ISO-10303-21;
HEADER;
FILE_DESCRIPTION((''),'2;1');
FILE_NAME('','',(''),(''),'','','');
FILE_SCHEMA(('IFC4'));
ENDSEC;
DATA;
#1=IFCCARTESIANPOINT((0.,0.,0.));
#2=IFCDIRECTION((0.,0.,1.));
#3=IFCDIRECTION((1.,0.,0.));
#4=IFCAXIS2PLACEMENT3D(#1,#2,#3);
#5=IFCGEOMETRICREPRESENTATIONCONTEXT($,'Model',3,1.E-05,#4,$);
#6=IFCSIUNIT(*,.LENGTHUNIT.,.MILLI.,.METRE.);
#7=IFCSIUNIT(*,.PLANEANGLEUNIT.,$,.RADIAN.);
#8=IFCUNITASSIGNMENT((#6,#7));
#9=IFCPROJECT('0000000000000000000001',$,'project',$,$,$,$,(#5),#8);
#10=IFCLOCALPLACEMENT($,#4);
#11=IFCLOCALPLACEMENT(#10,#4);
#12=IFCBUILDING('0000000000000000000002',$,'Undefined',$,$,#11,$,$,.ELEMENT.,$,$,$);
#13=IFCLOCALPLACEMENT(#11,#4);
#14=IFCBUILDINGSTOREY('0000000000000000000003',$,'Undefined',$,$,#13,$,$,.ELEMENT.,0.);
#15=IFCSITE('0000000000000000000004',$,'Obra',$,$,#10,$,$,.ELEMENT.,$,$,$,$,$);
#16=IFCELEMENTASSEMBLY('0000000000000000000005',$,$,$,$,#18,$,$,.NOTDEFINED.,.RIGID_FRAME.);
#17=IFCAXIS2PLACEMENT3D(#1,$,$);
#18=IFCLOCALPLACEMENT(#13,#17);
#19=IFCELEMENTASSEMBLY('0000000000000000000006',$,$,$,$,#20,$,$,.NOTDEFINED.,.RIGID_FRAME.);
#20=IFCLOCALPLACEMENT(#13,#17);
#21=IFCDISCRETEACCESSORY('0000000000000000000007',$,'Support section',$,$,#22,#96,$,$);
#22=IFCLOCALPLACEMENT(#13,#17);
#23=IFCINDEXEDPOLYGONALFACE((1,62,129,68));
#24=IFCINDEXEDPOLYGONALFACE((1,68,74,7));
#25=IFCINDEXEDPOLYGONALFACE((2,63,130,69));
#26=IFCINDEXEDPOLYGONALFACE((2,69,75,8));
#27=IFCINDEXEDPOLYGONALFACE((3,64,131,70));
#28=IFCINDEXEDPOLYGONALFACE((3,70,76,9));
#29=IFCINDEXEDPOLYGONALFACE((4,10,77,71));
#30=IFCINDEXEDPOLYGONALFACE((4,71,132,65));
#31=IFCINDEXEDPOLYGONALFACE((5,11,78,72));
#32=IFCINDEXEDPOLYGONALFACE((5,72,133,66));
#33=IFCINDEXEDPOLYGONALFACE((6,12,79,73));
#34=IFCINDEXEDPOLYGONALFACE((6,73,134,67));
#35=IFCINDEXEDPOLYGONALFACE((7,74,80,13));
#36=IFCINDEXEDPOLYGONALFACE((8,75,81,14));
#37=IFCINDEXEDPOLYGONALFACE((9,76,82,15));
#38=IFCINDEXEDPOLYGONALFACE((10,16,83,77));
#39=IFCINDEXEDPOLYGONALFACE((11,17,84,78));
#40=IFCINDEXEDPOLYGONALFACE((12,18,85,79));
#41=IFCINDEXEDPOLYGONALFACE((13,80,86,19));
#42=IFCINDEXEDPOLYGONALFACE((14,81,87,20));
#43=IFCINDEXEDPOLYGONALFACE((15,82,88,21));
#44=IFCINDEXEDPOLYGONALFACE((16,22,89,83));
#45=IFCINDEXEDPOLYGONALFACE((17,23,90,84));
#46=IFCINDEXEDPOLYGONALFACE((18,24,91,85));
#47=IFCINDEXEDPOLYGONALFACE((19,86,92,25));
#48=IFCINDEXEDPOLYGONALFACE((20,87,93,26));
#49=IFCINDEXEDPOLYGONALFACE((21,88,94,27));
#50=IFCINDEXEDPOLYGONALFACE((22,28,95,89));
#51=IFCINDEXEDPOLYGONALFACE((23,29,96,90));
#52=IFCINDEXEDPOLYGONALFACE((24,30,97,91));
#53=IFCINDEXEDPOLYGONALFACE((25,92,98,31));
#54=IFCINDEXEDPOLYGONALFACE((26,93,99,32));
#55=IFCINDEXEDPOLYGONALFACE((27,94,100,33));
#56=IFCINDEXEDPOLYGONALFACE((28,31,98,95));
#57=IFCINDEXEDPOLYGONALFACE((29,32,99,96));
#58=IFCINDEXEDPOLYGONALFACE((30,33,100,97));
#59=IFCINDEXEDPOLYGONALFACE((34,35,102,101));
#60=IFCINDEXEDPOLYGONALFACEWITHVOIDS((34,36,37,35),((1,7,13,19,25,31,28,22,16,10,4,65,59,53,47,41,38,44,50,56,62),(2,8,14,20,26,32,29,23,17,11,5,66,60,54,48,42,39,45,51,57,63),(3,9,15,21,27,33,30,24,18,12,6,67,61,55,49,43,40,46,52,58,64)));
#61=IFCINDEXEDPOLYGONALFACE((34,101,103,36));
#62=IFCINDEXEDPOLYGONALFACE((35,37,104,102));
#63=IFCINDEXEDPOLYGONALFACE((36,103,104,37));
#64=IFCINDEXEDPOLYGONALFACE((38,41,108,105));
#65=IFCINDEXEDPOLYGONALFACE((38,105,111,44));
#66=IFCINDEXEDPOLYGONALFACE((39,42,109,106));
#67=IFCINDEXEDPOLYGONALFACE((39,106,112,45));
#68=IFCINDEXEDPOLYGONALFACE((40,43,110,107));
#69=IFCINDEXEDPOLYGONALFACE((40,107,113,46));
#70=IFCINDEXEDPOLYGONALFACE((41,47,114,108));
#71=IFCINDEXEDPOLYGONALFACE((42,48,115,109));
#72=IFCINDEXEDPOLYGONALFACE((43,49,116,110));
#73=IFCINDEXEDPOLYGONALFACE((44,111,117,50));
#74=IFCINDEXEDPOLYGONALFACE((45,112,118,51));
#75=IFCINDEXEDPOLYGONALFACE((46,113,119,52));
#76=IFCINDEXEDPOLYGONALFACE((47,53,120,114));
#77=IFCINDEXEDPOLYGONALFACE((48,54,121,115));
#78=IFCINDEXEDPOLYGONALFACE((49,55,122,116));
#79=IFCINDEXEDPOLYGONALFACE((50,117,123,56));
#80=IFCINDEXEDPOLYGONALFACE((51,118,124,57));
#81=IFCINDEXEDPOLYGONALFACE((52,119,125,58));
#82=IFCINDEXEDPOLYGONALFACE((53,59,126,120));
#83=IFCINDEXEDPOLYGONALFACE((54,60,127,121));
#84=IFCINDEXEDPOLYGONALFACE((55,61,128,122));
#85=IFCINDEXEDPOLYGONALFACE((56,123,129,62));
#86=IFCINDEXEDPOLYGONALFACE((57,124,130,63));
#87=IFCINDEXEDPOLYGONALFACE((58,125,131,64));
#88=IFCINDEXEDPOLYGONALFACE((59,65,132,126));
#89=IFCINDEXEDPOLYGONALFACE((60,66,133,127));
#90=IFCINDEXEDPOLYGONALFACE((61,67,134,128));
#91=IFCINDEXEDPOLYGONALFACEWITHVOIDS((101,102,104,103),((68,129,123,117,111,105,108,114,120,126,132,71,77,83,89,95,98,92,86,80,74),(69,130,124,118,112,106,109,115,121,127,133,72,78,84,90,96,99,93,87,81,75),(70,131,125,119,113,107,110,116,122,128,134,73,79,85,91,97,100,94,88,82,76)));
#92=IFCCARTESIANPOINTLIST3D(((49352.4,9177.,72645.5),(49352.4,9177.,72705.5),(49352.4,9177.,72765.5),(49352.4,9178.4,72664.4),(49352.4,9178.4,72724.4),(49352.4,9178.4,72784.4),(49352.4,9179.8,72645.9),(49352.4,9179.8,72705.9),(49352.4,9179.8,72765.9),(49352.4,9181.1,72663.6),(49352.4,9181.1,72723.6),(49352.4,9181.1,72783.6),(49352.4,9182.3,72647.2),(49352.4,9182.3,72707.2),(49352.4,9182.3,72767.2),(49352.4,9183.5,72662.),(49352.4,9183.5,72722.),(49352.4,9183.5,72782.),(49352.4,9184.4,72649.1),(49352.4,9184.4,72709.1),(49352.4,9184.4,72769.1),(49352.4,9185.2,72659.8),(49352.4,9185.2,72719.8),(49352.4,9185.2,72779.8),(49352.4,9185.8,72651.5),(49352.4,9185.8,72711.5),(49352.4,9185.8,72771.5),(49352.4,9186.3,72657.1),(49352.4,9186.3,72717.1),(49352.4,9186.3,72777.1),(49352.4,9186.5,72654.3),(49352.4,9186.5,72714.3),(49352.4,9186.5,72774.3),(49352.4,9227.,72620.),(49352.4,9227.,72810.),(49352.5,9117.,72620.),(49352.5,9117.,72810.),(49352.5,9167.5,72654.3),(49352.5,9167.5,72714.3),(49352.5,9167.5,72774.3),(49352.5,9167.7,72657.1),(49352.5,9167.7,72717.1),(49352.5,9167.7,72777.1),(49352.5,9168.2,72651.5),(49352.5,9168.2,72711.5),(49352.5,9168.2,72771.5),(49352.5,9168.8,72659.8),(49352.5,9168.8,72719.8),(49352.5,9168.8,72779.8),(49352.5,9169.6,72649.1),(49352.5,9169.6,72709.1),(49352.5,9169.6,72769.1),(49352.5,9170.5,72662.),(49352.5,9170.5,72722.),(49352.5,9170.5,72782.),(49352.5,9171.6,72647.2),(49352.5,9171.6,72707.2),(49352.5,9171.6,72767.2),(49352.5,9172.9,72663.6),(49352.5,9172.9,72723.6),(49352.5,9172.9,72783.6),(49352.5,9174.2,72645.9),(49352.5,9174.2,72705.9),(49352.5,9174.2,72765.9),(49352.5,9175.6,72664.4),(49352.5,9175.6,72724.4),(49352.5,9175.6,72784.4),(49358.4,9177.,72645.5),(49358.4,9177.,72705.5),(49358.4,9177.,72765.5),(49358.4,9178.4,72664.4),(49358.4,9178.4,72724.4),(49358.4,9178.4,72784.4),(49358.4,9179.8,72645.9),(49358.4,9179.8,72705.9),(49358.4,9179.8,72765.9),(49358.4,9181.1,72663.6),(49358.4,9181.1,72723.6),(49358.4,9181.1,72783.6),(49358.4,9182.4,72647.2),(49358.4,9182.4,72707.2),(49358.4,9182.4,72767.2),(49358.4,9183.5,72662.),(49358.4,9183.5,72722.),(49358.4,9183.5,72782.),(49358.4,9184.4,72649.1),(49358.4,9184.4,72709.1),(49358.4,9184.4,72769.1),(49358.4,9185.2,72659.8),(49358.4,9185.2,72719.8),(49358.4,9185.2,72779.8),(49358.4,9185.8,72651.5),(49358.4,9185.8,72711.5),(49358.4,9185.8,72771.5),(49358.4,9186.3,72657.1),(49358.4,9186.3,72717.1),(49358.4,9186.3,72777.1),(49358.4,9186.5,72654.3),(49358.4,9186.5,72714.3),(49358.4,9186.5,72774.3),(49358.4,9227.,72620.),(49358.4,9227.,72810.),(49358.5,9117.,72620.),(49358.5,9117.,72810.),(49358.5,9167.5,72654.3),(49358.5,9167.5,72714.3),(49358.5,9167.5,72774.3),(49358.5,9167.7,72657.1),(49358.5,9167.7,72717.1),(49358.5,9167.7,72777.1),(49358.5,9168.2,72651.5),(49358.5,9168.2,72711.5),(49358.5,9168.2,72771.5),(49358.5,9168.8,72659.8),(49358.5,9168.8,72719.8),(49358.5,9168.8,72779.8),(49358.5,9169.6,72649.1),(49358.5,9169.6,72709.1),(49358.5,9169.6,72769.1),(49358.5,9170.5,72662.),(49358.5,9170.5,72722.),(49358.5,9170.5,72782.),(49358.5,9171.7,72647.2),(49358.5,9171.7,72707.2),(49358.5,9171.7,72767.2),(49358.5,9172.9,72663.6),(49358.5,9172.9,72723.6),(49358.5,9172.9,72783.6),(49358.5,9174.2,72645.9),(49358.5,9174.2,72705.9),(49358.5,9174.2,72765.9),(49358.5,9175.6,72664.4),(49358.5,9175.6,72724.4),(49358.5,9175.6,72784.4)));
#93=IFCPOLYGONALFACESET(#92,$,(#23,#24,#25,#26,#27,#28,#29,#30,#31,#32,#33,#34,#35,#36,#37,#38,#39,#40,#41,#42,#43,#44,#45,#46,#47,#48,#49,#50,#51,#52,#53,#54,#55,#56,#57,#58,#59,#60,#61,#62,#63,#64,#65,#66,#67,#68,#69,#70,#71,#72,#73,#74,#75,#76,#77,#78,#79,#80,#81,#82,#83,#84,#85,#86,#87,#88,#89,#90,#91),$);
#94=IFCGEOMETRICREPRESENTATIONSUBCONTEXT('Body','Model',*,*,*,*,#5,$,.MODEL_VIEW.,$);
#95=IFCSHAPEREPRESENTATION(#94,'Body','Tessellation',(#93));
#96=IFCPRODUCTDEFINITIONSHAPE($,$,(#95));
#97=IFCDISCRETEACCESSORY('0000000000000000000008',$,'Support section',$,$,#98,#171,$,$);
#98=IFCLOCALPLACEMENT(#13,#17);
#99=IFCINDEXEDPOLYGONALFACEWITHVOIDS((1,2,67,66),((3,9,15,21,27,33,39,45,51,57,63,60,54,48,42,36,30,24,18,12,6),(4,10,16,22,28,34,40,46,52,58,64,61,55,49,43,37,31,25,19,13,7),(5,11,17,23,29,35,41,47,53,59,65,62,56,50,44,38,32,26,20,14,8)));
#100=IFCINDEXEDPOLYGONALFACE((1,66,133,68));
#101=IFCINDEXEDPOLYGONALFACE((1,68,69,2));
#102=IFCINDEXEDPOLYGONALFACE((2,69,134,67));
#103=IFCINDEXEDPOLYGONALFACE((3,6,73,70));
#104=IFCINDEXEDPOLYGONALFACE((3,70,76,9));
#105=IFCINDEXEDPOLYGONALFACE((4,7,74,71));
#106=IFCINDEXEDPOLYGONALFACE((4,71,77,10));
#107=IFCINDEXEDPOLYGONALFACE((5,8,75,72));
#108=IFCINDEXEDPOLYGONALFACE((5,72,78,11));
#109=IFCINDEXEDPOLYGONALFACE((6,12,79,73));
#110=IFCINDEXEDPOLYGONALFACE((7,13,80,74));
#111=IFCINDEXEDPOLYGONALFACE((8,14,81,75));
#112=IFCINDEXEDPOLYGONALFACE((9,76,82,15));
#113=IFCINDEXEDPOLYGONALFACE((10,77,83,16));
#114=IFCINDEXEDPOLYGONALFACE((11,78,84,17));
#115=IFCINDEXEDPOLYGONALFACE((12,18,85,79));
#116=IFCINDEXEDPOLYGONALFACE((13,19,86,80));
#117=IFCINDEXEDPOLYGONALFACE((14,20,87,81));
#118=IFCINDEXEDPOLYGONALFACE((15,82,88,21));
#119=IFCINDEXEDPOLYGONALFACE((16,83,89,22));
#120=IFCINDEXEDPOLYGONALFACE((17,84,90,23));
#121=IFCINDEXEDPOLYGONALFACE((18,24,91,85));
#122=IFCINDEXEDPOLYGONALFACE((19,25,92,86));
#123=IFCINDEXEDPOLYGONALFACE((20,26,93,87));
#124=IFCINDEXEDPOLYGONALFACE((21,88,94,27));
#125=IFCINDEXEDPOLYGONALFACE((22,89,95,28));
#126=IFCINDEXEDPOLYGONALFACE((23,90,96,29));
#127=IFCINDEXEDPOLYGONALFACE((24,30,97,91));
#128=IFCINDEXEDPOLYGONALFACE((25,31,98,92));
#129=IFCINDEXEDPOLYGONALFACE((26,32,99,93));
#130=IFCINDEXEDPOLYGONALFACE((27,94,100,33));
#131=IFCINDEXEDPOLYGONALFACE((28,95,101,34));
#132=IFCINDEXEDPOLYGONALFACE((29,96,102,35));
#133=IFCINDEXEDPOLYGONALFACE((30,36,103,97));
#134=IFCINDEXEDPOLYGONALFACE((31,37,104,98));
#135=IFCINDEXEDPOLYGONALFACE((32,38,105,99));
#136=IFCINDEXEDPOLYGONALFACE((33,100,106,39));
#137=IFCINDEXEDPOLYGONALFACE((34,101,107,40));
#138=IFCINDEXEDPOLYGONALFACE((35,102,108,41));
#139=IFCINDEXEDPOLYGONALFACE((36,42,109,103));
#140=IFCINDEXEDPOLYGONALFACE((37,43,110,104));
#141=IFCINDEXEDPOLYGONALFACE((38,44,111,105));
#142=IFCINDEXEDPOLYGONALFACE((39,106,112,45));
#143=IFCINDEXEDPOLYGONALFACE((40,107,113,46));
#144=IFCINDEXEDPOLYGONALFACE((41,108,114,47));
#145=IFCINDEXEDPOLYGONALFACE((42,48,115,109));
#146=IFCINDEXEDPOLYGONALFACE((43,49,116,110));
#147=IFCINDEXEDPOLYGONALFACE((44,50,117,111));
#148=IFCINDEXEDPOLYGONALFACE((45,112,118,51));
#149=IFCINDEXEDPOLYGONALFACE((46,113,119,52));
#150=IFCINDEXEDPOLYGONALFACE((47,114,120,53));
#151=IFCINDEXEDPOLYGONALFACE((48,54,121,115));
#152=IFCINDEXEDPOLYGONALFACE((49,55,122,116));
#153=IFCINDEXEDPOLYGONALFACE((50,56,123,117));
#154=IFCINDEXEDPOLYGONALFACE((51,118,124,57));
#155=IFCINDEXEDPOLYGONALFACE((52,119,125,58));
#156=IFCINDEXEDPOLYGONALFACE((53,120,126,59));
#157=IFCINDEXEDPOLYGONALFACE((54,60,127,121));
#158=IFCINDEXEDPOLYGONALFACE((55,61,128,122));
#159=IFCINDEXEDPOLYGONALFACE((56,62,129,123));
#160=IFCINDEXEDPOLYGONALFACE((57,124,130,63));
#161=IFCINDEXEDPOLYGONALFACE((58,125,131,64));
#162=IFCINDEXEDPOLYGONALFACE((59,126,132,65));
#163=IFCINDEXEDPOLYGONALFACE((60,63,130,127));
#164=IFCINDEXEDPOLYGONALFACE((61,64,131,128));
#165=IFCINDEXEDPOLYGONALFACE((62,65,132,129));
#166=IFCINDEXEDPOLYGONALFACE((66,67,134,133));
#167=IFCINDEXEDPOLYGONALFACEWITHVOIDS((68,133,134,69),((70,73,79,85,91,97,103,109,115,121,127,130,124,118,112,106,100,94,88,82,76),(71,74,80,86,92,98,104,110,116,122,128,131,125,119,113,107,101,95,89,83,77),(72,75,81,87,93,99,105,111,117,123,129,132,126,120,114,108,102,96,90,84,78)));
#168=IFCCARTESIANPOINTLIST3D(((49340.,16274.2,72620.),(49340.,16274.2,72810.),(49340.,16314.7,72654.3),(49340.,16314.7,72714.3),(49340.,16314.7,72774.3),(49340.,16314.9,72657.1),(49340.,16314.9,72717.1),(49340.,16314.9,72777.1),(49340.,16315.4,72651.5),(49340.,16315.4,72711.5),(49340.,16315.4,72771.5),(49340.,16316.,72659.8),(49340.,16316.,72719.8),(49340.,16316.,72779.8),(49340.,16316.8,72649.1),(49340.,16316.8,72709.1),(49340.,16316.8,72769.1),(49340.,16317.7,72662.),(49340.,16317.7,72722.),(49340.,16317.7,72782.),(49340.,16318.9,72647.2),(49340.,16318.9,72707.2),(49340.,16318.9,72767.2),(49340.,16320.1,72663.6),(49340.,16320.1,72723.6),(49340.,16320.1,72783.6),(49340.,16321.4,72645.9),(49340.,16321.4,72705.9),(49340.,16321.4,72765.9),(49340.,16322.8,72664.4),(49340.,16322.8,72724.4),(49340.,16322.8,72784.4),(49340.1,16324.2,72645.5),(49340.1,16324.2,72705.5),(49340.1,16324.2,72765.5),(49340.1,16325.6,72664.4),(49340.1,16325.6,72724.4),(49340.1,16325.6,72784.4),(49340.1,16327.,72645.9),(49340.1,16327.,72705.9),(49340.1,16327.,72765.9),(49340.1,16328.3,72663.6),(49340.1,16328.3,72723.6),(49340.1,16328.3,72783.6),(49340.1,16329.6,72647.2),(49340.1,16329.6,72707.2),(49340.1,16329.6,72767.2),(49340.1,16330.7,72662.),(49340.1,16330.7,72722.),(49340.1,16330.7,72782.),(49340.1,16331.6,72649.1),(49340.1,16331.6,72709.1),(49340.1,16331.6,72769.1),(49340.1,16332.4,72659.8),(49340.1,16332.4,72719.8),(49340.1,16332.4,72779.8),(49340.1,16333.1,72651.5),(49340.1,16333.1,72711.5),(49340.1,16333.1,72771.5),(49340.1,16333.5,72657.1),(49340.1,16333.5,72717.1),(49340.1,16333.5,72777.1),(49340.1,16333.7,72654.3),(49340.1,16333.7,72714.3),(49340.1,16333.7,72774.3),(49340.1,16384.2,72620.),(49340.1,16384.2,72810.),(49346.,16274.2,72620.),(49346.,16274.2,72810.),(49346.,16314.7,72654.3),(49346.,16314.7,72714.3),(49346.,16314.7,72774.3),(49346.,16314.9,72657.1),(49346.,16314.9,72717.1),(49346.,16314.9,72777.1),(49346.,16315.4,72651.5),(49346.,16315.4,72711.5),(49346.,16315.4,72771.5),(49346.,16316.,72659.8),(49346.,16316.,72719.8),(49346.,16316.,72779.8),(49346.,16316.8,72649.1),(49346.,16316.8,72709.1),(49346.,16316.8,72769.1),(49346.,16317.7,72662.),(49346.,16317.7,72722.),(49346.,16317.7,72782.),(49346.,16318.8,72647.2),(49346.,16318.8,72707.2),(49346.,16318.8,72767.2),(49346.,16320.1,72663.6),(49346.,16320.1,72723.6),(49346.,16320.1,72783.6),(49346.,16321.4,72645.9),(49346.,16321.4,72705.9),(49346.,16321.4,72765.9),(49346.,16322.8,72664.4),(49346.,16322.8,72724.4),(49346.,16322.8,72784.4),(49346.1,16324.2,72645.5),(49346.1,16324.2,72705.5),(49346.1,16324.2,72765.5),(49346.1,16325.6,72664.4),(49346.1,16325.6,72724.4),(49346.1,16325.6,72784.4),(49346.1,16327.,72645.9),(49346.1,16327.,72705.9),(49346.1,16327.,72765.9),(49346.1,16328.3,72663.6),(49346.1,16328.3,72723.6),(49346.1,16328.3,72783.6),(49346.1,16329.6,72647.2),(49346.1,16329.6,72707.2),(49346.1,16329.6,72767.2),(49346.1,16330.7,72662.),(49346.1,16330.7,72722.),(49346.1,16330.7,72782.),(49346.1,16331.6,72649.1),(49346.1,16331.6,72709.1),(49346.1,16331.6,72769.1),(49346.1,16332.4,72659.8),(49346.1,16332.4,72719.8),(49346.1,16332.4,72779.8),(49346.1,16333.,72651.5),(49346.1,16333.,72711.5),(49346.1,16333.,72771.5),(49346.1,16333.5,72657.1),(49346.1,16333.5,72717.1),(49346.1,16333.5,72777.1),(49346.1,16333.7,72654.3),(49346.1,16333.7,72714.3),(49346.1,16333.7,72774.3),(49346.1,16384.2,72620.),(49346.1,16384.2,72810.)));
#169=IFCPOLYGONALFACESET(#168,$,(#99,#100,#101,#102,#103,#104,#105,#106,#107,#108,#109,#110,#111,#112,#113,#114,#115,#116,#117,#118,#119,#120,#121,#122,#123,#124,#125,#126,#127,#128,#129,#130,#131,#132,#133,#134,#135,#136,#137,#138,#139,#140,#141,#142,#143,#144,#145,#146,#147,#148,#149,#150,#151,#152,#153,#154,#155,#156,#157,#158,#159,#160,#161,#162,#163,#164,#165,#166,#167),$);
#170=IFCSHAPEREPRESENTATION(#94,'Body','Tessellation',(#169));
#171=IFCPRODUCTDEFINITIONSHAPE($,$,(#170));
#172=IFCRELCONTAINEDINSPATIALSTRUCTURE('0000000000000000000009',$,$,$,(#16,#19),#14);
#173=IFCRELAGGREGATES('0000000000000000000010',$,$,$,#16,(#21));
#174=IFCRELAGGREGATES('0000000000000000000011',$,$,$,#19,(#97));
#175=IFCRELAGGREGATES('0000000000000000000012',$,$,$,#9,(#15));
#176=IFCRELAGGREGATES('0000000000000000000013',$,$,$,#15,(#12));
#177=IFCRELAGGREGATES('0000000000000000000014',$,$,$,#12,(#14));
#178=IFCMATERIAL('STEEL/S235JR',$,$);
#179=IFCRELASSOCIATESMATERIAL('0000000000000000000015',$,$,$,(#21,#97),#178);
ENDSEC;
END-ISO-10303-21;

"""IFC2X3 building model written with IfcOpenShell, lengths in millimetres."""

from ifc_helpers import new_model, si_unit, frame, origin_with_axes, origin_2d_with_axis, place, context, subcontext, project, spatial, rectangle, circle, extrude, source, transform, mapped, material, element, aggregate, save


model = new_model("IFC2X3")

# Units and contexts
model_context = context("Model", 3, precision=1e-05, world=origin_with_axes())
body_context = subcontext(model_context, "Body", "Model", "MODEL_VIEW")
ifc_project = project(units=[si_unit("LENGTHUNIT", "METRE", prefix="MILLI"), si_unit("PLANEANGLEUNIT", "RADIAN")], contexts=[model_context])

# Site, building, storey
site_placement = place(None, origin_with_axes())
site = spatial("IfcSite", under=ifc_project, at=site_placement, Name="Obra", CompositionType="ELEMENT")
building_placement = place(site_placement, origin_with_axes())
building = spatial("IfcBuilding", under=site, at=building_placement, Name="Undefined", CompositionType="ELEMENT")
storey_placement = place(building_placement, origin_with_axes())
storey = spatial("IfcBuildingStorey", under=building, at=storey_placement, Name="Undefined", CompositionType="ELEMENT", Elevation=0.0)

# Element assemblies
assembly_1_placement = place(storey_placement, origin_with_axes())
assembly_1 = element("IfcElementAssembly", 1, at=assembly_1_placement, inside=storey, AssemblyPlace="NOTDEFINED", PredefinedType="RIGID_FRAME")
ifc_material_1 = material(Name="STEEL/S235JR")
assembly_2_placement = place(storey_placement, origin_with_axes())
assembly_2 = element("IfcElementAssembly", 2, at=assembly_2_placement, inside=storey, AssemblyPlace="NOTDEFINED", PredefinedType="RIGID_FRAME")

# Shared definitions
shared_shape = source(origin_with_axes(), body_context, "Body", "SweptSolid", [
    extrude(circle(Radius=9.5, at=origin_2d_with_axis()), frame((0.0, -9.2, 0.0), z_axis=(0.0, 1.0, 0.0), x_axis=(1.0, 0.0, 0.0)), (0.0, 0.0, 1.0), 6.2),
])

# Discrete accessories, openings
discrete_accessory_1_placement = place(assembly_1_placement, frame((49355.5, 9172.0, 72620.0), z_axis=(0.0, 0.0, 1.0), x_axis=(0.001508, -0.999999, 0.0)))
discrete_accessory_1 = element("IfcDiscreteAccessory", 3, at=discrete_accessory_1_placement, material=ifc_material_1, Name="Support section", context=body_context, shape_type="SweptSolid", body=[
    extrude(rectangle(XDim=6.0, YDim=110.0, at=origin_2d_with_axis()), frame((0.0, 0.0, 190.0), z_axis=(0.0, 0.0, -1.0), x_axis=(0.0, 1.0, 0.0)), (0.0, 0.0, 1.0), 190.0),
])
opening_1_placement = place(assembly_1_placement, frame((49349.4, 9127.0, 72835.0), z_axis=(-0.001508, 0.999999, 0.0), x_axis=(0.0, 0.0, -1.0)))
element("IfcOpeningElement", 4, at=opening_1_placement, cuts=discrete_accessory_1, ObjectType="Opening", context=body_context, shape_type="MappedRepresentation", body=[
    mapped(shared_shape, transform((60.0, 0.0, 50.0))),
    mapped(shared_shape, transform((120.0, 0.0, 50.0))),
    mapped(shared_shape, transform((180.0, 0.0, 50.0))),
])
aggregate(assembly_1, [discrete_accessory_1])
discrete_accessory_2_placement = place(assembly_2_placement, frame((49343.1, 16329.2, 72620.0), z_axis=(0.0, 0.0, 1.0), x_axis=(0.001649, 0.999999, 0.0)))
discrete_accessory_2 = element("IfcDiscreteAccessory", 5, at=discrete_accessory_2_placement, material=ifc_material_1, Name="Support section", context=body_context, shape_type="SweptSolid", body=[
    extrude(rectangle(XDim=6.0, YDim=110.0, at=origin_2d_with_axis()), frame((0.0, 0.0, 190.0), z_axis=(0.0, 0.0, -1.0), x_axis=(0.0, 1.0, 0.0)), (0.0, 0.0, 1.0), 190.0),
])
opening_2_placement = place(assembly_2_placement, frame((49349.2, 16374.2, 72835.0), z_axis=(-0.001649, -0.999999, 0.0), x_axis=(0.0, 0.0, -1.0)))
element("IfcOpeningElement", 6, at=opening_2_placement, cuts=discrete_accessory_2, ObjectType="Opening", context=body_context, shape_type="MappedRepresentation", body=[
    mapped(shared_shape, transform((60.0, 0.0, 50.0))),
    mapped(shared_shape, transform((120.0, 0.0, 50.0))),
    mapped(shared_shape, transform((180.0, 0.0, 50.0))),
])
aggregate(assembly_2, [discrete_accessory_2])

save(model, "model.ifc")
